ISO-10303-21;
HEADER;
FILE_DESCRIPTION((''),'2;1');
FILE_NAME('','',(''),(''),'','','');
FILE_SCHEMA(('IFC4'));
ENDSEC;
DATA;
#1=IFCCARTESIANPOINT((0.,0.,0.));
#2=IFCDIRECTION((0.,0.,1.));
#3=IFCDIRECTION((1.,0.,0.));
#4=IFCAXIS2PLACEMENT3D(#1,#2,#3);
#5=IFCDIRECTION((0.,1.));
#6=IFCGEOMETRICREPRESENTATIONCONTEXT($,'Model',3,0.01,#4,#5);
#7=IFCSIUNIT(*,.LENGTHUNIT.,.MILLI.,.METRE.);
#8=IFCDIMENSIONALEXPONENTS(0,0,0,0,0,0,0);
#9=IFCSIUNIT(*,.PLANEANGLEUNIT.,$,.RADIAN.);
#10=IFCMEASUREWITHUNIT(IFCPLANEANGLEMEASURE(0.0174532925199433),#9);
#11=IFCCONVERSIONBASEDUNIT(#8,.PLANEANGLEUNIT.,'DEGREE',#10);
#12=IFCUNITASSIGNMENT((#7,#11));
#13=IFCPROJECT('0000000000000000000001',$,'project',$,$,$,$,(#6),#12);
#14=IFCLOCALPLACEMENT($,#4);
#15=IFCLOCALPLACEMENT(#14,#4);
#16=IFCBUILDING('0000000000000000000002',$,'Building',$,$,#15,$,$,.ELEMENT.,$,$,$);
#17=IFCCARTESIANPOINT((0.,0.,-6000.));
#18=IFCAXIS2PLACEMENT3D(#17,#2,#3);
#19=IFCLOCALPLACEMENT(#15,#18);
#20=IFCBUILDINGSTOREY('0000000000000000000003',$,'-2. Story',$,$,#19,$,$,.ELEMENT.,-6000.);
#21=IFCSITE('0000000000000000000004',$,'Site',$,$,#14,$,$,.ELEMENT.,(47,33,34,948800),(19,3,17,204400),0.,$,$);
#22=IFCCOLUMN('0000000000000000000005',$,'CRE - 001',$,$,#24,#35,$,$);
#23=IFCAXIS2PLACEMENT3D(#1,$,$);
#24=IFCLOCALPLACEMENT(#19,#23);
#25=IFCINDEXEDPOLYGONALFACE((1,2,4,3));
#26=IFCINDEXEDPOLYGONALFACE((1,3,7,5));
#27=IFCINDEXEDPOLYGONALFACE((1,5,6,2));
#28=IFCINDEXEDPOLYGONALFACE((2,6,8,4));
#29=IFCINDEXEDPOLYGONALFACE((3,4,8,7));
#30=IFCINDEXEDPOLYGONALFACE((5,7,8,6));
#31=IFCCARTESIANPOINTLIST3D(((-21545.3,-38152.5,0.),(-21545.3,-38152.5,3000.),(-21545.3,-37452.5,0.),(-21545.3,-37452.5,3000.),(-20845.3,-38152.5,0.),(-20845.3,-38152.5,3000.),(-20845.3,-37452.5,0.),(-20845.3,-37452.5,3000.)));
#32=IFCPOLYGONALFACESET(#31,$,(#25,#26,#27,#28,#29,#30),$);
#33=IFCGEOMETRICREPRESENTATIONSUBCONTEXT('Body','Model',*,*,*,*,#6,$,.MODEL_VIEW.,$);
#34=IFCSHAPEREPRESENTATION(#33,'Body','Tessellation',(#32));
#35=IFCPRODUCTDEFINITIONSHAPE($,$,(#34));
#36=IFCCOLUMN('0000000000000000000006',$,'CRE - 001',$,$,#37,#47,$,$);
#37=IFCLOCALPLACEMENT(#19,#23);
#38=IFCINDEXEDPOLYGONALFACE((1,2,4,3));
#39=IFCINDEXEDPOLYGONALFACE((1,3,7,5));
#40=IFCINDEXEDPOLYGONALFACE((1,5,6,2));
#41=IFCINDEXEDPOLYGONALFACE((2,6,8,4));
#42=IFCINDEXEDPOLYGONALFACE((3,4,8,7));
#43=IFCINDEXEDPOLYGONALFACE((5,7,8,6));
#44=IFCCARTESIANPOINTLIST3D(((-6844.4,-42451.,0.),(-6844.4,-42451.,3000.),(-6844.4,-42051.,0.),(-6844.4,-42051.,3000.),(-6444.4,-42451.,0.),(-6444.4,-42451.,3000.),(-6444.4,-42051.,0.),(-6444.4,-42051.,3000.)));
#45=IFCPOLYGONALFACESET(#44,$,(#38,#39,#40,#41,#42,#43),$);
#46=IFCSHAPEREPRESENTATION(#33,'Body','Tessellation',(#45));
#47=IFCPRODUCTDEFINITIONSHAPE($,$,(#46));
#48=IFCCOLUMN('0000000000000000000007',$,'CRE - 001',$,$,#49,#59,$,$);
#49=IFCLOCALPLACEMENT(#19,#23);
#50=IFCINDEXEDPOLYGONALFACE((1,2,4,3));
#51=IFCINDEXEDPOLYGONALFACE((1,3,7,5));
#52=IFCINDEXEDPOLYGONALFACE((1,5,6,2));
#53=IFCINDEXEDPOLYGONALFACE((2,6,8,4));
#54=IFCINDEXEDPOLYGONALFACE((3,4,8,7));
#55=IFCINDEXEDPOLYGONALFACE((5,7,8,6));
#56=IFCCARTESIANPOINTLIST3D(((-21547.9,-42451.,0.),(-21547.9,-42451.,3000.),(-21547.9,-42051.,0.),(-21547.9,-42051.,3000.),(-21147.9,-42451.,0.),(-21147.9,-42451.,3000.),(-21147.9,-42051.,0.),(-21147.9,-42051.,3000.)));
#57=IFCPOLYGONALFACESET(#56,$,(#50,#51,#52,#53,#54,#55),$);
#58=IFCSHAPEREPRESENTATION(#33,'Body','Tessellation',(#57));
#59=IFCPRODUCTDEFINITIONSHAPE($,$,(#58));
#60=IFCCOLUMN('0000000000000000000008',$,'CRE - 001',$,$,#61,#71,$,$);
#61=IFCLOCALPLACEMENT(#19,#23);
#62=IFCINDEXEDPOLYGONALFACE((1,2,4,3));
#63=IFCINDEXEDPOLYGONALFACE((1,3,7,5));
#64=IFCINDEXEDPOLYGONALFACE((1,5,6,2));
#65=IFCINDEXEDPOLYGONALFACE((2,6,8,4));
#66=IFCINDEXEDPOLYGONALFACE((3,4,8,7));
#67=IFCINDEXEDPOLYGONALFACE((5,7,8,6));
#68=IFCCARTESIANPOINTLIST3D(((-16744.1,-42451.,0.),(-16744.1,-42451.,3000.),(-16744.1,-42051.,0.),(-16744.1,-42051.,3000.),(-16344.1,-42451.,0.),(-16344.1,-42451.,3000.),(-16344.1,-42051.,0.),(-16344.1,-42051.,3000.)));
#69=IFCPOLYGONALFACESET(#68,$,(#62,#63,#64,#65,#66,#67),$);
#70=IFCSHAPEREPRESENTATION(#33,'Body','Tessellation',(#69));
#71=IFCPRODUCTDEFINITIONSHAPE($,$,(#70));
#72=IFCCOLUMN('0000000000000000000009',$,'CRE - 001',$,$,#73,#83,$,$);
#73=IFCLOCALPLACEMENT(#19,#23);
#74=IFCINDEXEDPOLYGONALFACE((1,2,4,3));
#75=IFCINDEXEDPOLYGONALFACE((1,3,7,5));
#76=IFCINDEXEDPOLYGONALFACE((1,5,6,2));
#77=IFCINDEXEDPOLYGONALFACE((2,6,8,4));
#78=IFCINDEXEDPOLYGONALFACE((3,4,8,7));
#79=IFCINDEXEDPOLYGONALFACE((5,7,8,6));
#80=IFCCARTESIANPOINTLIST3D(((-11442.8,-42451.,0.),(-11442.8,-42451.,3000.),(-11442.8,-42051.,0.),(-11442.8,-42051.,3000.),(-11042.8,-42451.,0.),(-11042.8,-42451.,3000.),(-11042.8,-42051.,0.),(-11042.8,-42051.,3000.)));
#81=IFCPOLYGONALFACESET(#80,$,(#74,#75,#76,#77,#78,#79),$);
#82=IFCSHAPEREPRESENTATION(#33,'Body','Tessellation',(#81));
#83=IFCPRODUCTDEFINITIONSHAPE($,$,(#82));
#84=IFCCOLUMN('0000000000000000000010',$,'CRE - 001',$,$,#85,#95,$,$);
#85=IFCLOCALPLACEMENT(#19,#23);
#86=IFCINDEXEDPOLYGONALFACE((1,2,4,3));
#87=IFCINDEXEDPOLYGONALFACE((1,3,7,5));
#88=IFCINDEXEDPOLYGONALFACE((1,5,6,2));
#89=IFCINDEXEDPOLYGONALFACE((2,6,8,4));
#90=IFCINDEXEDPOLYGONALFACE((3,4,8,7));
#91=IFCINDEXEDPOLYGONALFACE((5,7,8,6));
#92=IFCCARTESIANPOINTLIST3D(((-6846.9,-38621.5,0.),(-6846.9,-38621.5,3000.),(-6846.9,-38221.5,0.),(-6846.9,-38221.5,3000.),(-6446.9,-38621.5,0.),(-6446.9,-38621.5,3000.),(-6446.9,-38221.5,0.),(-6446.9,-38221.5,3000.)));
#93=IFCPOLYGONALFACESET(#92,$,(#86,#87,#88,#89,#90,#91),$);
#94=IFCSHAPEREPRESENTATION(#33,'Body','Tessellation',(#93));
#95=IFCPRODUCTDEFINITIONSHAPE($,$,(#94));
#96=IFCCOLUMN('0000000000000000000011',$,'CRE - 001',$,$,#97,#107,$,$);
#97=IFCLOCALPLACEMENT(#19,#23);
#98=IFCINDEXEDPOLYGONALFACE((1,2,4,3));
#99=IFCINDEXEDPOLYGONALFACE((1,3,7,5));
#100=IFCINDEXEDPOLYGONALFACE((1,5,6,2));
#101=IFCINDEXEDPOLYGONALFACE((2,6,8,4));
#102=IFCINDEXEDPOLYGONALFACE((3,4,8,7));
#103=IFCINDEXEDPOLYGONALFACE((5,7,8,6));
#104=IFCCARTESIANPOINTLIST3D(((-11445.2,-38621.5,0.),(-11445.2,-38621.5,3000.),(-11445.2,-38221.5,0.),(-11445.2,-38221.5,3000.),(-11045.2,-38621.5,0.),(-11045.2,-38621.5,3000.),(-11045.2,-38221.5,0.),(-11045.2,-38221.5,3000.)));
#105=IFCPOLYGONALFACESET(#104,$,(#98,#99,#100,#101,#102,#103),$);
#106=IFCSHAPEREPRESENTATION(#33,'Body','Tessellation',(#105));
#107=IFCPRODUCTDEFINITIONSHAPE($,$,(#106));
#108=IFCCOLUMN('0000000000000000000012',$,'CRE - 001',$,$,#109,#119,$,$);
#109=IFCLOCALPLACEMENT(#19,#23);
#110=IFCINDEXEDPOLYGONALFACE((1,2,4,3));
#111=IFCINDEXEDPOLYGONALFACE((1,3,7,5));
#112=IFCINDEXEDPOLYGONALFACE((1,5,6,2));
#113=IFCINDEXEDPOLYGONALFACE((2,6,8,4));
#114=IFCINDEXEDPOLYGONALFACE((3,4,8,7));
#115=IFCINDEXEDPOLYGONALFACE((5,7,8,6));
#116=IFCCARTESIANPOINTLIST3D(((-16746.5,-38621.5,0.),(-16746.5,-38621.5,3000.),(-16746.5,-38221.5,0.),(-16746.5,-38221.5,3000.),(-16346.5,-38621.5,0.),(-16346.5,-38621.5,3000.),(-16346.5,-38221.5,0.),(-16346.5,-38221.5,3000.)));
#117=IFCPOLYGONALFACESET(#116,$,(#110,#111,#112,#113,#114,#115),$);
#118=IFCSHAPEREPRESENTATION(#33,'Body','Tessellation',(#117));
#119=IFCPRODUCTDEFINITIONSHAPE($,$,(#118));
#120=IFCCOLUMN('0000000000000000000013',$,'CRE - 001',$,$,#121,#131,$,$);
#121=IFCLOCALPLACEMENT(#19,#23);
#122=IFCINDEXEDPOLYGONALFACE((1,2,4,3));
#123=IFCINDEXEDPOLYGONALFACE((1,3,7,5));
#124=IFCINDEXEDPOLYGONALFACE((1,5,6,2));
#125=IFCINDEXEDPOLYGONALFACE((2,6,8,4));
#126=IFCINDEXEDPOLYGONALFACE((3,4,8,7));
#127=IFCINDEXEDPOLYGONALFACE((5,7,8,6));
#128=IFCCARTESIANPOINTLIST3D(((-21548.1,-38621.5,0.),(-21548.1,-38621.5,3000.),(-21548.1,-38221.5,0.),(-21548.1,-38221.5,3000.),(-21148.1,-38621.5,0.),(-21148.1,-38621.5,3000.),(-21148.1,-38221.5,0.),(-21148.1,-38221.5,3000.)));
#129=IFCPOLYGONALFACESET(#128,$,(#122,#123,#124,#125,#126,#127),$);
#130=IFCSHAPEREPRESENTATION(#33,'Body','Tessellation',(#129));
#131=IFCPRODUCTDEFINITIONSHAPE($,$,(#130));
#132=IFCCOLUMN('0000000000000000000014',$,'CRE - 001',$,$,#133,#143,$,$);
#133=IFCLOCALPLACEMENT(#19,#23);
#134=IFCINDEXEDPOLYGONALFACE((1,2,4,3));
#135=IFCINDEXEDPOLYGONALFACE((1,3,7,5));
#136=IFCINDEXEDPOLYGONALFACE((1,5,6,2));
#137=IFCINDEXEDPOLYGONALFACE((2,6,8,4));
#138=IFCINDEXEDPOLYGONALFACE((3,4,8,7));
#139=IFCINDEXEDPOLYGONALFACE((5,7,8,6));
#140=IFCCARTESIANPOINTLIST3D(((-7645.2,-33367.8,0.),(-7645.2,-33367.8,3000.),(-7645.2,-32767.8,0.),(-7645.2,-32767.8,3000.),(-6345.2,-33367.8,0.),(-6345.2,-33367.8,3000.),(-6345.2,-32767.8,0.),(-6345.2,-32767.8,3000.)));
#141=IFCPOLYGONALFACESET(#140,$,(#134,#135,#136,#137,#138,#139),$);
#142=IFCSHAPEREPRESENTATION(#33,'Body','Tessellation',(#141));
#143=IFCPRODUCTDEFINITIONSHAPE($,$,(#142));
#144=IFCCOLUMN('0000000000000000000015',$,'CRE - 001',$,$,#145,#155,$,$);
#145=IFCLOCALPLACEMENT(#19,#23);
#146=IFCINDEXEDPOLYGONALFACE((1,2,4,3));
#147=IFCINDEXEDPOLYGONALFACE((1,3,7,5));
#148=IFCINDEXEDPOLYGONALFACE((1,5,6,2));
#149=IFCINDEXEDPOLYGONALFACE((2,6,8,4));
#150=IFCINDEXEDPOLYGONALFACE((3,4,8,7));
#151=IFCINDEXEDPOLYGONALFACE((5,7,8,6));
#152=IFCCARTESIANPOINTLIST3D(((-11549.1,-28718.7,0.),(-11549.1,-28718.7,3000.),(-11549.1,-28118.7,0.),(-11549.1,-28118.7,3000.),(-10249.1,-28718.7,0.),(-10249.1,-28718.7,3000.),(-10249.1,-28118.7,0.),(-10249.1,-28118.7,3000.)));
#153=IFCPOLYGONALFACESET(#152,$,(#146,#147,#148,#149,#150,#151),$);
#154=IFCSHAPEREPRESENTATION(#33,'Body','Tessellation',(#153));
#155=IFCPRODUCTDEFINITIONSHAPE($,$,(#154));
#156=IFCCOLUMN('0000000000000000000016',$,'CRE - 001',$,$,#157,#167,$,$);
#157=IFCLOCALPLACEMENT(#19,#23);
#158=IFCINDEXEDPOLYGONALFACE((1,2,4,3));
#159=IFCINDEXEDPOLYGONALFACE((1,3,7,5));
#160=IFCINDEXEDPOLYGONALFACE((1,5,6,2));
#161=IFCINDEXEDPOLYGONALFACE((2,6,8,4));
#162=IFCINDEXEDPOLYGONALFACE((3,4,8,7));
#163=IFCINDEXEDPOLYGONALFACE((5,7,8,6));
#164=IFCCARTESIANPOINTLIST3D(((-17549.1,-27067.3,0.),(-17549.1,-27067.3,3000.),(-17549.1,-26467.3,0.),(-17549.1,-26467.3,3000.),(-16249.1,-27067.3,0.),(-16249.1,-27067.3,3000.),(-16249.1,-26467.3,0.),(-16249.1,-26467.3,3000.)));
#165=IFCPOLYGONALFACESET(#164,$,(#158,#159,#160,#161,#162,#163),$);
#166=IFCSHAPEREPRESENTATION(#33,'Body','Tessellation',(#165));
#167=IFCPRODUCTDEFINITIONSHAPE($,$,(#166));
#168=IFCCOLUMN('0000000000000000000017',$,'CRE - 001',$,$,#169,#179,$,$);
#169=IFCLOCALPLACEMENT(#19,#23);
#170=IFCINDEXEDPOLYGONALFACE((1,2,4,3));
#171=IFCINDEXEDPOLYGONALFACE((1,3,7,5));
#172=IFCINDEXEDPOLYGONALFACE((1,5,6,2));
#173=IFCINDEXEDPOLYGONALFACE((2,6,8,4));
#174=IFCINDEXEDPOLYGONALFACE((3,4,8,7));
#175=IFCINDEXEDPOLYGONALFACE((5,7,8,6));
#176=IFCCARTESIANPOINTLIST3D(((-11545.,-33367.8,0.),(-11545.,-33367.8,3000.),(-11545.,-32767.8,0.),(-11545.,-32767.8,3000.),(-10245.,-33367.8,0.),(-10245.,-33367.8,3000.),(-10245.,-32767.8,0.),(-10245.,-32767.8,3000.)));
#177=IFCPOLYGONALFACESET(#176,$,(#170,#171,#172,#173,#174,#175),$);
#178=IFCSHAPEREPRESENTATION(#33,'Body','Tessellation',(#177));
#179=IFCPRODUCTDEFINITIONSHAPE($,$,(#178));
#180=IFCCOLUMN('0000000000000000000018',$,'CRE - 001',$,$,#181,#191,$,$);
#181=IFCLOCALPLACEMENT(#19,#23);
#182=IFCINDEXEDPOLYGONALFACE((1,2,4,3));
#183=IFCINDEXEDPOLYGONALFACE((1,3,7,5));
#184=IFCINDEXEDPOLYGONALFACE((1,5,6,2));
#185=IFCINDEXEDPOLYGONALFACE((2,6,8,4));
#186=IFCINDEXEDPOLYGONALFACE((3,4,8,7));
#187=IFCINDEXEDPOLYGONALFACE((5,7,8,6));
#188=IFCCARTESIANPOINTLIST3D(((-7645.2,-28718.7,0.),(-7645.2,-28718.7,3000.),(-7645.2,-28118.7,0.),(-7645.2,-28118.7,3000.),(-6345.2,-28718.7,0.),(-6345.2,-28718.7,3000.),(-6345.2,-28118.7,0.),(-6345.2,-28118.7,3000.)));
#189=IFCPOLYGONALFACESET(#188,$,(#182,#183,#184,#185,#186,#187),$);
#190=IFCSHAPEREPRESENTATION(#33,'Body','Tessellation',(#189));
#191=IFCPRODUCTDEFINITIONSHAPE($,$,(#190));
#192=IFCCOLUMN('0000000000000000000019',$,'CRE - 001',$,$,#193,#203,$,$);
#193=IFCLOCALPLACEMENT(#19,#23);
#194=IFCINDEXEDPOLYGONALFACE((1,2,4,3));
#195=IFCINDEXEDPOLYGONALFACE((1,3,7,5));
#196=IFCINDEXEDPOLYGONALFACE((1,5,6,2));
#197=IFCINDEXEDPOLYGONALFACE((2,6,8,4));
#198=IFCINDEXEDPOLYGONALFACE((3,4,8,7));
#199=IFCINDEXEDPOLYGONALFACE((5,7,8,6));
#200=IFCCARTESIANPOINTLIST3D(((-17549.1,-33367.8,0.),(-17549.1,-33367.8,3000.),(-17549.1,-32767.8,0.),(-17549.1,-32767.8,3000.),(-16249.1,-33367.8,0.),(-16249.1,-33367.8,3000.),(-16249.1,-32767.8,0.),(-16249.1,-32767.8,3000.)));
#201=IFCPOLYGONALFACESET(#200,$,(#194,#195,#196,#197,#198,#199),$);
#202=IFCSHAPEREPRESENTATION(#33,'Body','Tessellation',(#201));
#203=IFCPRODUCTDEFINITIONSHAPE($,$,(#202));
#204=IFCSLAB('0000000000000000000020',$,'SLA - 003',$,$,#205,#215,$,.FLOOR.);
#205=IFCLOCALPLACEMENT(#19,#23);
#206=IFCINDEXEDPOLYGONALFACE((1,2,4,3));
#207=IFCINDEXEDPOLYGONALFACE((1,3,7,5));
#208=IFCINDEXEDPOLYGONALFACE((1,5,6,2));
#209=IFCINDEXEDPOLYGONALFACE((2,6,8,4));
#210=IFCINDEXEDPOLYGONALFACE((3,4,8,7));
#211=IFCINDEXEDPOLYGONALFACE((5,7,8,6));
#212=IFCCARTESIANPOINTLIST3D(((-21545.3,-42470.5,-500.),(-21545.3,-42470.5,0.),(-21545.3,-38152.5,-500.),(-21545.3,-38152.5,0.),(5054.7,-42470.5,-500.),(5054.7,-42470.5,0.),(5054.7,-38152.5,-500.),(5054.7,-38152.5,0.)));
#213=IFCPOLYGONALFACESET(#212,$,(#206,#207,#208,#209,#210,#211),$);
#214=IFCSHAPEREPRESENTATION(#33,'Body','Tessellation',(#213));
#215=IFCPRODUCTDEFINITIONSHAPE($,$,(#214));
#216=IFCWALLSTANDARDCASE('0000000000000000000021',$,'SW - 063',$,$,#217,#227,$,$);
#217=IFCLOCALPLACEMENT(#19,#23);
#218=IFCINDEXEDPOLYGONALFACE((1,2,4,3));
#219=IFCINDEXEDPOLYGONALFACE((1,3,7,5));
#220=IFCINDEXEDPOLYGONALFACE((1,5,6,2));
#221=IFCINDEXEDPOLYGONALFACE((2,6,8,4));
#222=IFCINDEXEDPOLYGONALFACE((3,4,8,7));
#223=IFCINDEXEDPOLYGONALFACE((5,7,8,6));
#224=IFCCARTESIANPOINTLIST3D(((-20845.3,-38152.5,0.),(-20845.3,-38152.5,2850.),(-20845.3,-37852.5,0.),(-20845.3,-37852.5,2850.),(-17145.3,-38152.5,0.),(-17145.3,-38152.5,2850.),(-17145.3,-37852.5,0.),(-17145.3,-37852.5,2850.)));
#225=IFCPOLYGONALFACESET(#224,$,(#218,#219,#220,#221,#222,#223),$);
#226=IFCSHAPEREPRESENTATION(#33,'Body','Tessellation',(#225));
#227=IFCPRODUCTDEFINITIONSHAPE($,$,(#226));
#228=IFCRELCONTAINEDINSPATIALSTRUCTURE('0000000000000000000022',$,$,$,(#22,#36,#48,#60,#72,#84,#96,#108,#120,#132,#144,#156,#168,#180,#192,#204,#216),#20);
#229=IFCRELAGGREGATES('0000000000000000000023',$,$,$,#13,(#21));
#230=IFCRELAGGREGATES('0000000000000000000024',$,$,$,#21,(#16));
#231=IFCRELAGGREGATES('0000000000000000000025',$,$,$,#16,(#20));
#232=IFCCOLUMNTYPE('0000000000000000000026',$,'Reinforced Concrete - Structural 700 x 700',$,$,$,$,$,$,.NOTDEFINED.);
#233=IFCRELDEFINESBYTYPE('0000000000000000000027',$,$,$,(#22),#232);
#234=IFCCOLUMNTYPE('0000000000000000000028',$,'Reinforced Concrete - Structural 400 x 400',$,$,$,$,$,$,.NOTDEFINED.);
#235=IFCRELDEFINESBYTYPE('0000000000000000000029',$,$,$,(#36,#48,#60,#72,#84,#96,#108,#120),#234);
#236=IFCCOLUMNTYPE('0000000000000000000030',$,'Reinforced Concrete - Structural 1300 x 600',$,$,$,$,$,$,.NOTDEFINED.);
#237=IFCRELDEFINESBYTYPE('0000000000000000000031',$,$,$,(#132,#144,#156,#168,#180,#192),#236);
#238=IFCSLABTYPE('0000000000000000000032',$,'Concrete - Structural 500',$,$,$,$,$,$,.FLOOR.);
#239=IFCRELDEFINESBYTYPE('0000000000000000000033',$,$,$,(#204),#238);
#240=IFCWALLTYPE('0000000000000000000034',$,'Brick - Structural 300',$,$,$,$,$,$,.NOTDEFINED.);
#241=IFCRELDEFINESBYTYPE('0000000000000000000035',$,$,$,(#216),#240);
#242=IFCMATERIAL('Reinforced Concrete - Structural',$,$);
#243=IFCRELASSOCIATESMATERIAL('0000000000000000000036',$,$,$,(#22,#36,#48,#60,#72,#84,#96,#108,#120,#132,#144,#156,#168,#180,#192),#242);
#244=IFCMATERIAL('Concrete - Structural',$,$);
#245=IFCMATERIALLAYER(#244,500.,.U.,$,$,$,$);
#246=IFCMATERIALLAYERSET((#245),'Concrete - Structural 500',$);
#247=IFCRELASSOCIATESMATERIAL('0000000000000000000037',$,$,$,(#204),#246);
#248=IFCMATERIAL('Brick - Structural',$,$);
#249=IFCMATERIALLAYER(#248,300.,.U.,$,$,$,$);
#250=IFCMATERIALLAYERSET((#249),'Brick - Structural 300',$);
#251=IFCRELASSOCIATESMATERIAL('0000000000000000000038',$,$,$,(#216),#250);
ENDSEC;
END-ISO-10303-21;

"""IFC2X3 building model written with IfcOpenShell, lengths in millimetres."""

from ifc_helpers import new_model, entity, si_unit, converted_unit, direction, frame, origin_with_axes, origin_2d_with_axis, place, context, subcontext, project, spatial, polyline, rectangle, outline, extrude, material, layer, layer_set, layer_usage, type_object, element, save


model = new_model("IFC2X3")

# Units and contexts
model_context = context("Model", 3, precision=0.01, world=origin_with_axes(), true_north=direction((0.0, 1.0)))
body_context = subcontext(model_context, "Body", "Model", "MODEL_VIEW")
ifc_project = project(units=[si_unit("LENGTHUNIT", "METRE", prefix="MILLI"), converted_unit("PLANEANGLEUNIT", "DEGREE", entity("IfcPlaneAngleMeasure", 0.0174532925199433), si_unit("PLANEANGLEUNIT", "RADIAN"), dimensions=[0, 0, 0, 0, 0, 0, 0])], contexts=[model_context])

# Site, building, storey
site_placement = place(None, origin_with_axes())
site = spatial("IfcSite", under=ifc_project, at=site_placement, Name="Site", CompositionType="ELEMENT", RefLatitude=(47, 33, 34, 948800), RefLongitude=(19, 3, 17, 204400), RefElevation=0.0)
building_placement = place(site_placement, origin_with_axes())
building = spatial("IfcBuilding", under=site, at=building_placement, Name="Building", CompositionType="ELEMENT")
storey_placement = place(building_placement, frame((0.0, 0.0, -6000.0), z_axis=(0.0, 0.0, 1.0), x_axis=(1.0, 0.0, 0.0)))
storey = spatial("IfcBuildingStorey", under=building, at=storey_placement, Name="-2. Story", CompositionType="ELEMENT", Elevation=-6000.0)

# Columns
ifc_material_1 = material(Name="Reinforced Concrete - Structural")
column_type_1 = type_object("IfcColumnType", Name="Reinforced Concrete - Structural 700 x 700", PredefinedType="NOTDEFINED")
column_placement = place(storey_placement, frame((-21195.3, -37802.5, 0.0), z_axis=(0.0, 0.0, 1.0), x_axis=(1.0, 0.0, 0.0)))
element("IfcColumn", 1, at=column_placement, inside=storey, type_object=column_type_1, material=ifc_material_1, Name="CRE - 001", context=body_context, shape_type="SweptSolid", body=[
    extrude(rectangle(XDim=700.0, YDim=700.0, at=origin_2d_with_axis()), origin_with_axes(), (0.0, 0.0, 1.0), 3000.0),
])
column_type_2 = type_object("IfcColumnType", Name="Reinforced Concrete - Structural 400 x 400", PredefinedType="NOTDEFINED")
for number, where, z_axis, x_axis, name in (
    (2, (-6644.4, -42251.0, 0.0), (0.0, 0.0, 1.0), (1.0, 0.0, 0.0), "CRE - 001"),
    (3, (-21347.9, -42251.0, 0.0), (0.0, 0.0, 1.0), (1.0, 0.0, 0.0), "CRE - 001"),
    (4, (-16544.1, -42251.0, 0.0), (0.0, 0.0, 1.0), (1.0, 0.0, 0.0), "CRE - 001"),
    (5, (-11242.8, -42251.0, 0.0), (0.0, 0.0, 1.0), (1.0, 0.0, 0.0), "CRE - 001"),
    (6, (-6646.9, -38421.5, 0.0), (0.0, 0.0, 1.0), (1.0, 0.0, 0.0), "CRE - 001"),
    (7, (-11245.2, -38421.5, 0.0), (0.0, 0.0, 1.0), (1.0, 0.0, 0.0), "CRE - 001"),
    (8, (-16546.5, -38421.5, 0.0), (0.0, 0.0, 1.0), (1.0, 0.0, 0.0), "CRE - 001"),
    (9, (-21348.1, -38421.5, 0.0), (0.0, 0.0, 1.0), (1.0, 0.0, 0.0), "CRE - 001"),
):
    element("IfcColumn", number, at=place(storey_placement, frame(where, z_axis=z_axis, x_axis=x_axis)), inside=storey, type_object=column_type_2, material=ifc_material_1, Name=name, context=body_context, shape_type="SweptSolid", body=[
        extrude(rectangle(XDim=400.0, YDim=400.0, at=origin_2d_with_axis()), origin_with_axes(), (0.0, 0.0, 1.0), 3000.0),
    ])
column_type_3 = type_object("IfcColumnType", Name="Reinforced Concrete - Structural 1300 x 600", PredefinedType="NOTDEFINED")
for number, where, z_axis, x_axis, name in (
    (10, (-6995.2, -33067.8, 0.0), (0.0, 0.0, 1.0), (1.0, 0.0, 0.0), "CRE - 001"),
    (11, (-10899.1, -28418.7, 0.0), (0.0, 0.0, 1.0), (1.0, 0.0, 0.0), "CRE - 001"),
    (12, (-16899.1, -26767.3, 0.0), (0.0, 0.0, 1.0), (1.0, 0.0, 0.0), "CRE - 001"),
    (13, (-10895.0, -33067.8, 0.0), (0.0, 0.0, 1.0), (1.0, 0.0, 0.0), "CRE - 001"),
    (14, (-6995.2, -28418.7, 0.0), (0.0, 0.0, 1.0), (1.0, 0.0, 0.0), "CRE - 001"),
    (15, (-16899.1, -33067.8, 0.0), (0.0, 0.0, 1.0), (1.0, 0.0, 0.0), "CRE - 001"),
):
    element("IfcColumn", number, at=place(storey_placement, frame(where, z_axis=z_axis, x_axis=x_axis)), inside=storey, type_object=column_type_3, material=ifc_material_1, Name=name, context=body_context, shape_type="SweptSolid", body=[
        extrude(rectangle(XDim=1300.0, YDim=600.0, at=origin_2d_with_axis()), origin_with_axes(), (0.0, 0.0, 1.0), 3000.0),
    ])

# Slab
ifc_material_2 = material(Name="Concrete - Structural")
ifc_layer_1 = layer(ifc_material_2, 500.0, ventilated="UNKNOWN")
ifc_layer_set_1 = layer_set([ifc_layer_1], Name="Concrete - Structural 500")
ifc_layer_usage_1 = layer_usage(ifc_layer_set_1, "AXIS3", "NEGATIVE", 500.0)
slab_type = type_object("IfcSlabType", Name="Concrete - Structural 500", PredefinedType="FLOOR")
slab_placement = place(storey_placement, frame((-21545.3, -38152.5, 0.0), z_axis=(0.0, 0.0, 1.0), x_axis=(1.0, 0.0, 0.0)))
element("IfcSlab", 16, at=slab_placement, inside=storey, type_object=slab_type, material=ifc_layer_usage_1, Name="SLA - 003", PredefinedType="FLOOR", context=body_context, shape_type="SweptSolid", body=[
    extrude(outline(polyline([(0.0, 0.0), (0.0, -4317.9), (26600.0, -4317.9), (26600.0, 0.0), (0.0, 0.0)])), frame((0.0, 0.0, -500.0), z_axis=(0.0, 0.0, 1.0), x_axis=(1.0, 0.0, 0.0)), (0.0, 0.0, 1.0), 500.0),
])

# Wall
ifc_material_3 = material(Name="Brick - Structural")
ifc_layer_2 = layer(ifc_material_3, 300.0, ventilated="UNKNOWN")
ifc_layer_set_2 = layer_set([ifc_layer_2], Name="Brick - Structural 300")
ifc_layer_usage_2 = layer_usage(ifc_layer_set_2, "AXIS2", "POSITIVE", 0.0)
wall_type_1 = type_object("IfcWallType", Name="Brick - Structural 300", PredefinedType="NOTDEFINED")
wall_1_placement = place(storey_placement, frame((-20845.3, -38152.5, 0.0), z_axis=(0.0, 0.0, 1.0), x_axis=(1.0, 0.0, 0.0)))
element("IfcWallStandardCase", 17, at=wall_1_placement, inside=storey, type_object=wall_type_1, material=ifc_layer_usage_2, Name="SW - 063", context=body_context, shape_type="SweptSolid", body=[
    extrude(outline(polyline([(0.0, 0.0), (3700.0, 0.0), (3700.0, 300.0), (0.0, 300.0), (0.0, 0.0)])), origin_with_axes(), (0.0, 0.0, 1.0), 2850.0),
])

save(model, "model.ifc")
